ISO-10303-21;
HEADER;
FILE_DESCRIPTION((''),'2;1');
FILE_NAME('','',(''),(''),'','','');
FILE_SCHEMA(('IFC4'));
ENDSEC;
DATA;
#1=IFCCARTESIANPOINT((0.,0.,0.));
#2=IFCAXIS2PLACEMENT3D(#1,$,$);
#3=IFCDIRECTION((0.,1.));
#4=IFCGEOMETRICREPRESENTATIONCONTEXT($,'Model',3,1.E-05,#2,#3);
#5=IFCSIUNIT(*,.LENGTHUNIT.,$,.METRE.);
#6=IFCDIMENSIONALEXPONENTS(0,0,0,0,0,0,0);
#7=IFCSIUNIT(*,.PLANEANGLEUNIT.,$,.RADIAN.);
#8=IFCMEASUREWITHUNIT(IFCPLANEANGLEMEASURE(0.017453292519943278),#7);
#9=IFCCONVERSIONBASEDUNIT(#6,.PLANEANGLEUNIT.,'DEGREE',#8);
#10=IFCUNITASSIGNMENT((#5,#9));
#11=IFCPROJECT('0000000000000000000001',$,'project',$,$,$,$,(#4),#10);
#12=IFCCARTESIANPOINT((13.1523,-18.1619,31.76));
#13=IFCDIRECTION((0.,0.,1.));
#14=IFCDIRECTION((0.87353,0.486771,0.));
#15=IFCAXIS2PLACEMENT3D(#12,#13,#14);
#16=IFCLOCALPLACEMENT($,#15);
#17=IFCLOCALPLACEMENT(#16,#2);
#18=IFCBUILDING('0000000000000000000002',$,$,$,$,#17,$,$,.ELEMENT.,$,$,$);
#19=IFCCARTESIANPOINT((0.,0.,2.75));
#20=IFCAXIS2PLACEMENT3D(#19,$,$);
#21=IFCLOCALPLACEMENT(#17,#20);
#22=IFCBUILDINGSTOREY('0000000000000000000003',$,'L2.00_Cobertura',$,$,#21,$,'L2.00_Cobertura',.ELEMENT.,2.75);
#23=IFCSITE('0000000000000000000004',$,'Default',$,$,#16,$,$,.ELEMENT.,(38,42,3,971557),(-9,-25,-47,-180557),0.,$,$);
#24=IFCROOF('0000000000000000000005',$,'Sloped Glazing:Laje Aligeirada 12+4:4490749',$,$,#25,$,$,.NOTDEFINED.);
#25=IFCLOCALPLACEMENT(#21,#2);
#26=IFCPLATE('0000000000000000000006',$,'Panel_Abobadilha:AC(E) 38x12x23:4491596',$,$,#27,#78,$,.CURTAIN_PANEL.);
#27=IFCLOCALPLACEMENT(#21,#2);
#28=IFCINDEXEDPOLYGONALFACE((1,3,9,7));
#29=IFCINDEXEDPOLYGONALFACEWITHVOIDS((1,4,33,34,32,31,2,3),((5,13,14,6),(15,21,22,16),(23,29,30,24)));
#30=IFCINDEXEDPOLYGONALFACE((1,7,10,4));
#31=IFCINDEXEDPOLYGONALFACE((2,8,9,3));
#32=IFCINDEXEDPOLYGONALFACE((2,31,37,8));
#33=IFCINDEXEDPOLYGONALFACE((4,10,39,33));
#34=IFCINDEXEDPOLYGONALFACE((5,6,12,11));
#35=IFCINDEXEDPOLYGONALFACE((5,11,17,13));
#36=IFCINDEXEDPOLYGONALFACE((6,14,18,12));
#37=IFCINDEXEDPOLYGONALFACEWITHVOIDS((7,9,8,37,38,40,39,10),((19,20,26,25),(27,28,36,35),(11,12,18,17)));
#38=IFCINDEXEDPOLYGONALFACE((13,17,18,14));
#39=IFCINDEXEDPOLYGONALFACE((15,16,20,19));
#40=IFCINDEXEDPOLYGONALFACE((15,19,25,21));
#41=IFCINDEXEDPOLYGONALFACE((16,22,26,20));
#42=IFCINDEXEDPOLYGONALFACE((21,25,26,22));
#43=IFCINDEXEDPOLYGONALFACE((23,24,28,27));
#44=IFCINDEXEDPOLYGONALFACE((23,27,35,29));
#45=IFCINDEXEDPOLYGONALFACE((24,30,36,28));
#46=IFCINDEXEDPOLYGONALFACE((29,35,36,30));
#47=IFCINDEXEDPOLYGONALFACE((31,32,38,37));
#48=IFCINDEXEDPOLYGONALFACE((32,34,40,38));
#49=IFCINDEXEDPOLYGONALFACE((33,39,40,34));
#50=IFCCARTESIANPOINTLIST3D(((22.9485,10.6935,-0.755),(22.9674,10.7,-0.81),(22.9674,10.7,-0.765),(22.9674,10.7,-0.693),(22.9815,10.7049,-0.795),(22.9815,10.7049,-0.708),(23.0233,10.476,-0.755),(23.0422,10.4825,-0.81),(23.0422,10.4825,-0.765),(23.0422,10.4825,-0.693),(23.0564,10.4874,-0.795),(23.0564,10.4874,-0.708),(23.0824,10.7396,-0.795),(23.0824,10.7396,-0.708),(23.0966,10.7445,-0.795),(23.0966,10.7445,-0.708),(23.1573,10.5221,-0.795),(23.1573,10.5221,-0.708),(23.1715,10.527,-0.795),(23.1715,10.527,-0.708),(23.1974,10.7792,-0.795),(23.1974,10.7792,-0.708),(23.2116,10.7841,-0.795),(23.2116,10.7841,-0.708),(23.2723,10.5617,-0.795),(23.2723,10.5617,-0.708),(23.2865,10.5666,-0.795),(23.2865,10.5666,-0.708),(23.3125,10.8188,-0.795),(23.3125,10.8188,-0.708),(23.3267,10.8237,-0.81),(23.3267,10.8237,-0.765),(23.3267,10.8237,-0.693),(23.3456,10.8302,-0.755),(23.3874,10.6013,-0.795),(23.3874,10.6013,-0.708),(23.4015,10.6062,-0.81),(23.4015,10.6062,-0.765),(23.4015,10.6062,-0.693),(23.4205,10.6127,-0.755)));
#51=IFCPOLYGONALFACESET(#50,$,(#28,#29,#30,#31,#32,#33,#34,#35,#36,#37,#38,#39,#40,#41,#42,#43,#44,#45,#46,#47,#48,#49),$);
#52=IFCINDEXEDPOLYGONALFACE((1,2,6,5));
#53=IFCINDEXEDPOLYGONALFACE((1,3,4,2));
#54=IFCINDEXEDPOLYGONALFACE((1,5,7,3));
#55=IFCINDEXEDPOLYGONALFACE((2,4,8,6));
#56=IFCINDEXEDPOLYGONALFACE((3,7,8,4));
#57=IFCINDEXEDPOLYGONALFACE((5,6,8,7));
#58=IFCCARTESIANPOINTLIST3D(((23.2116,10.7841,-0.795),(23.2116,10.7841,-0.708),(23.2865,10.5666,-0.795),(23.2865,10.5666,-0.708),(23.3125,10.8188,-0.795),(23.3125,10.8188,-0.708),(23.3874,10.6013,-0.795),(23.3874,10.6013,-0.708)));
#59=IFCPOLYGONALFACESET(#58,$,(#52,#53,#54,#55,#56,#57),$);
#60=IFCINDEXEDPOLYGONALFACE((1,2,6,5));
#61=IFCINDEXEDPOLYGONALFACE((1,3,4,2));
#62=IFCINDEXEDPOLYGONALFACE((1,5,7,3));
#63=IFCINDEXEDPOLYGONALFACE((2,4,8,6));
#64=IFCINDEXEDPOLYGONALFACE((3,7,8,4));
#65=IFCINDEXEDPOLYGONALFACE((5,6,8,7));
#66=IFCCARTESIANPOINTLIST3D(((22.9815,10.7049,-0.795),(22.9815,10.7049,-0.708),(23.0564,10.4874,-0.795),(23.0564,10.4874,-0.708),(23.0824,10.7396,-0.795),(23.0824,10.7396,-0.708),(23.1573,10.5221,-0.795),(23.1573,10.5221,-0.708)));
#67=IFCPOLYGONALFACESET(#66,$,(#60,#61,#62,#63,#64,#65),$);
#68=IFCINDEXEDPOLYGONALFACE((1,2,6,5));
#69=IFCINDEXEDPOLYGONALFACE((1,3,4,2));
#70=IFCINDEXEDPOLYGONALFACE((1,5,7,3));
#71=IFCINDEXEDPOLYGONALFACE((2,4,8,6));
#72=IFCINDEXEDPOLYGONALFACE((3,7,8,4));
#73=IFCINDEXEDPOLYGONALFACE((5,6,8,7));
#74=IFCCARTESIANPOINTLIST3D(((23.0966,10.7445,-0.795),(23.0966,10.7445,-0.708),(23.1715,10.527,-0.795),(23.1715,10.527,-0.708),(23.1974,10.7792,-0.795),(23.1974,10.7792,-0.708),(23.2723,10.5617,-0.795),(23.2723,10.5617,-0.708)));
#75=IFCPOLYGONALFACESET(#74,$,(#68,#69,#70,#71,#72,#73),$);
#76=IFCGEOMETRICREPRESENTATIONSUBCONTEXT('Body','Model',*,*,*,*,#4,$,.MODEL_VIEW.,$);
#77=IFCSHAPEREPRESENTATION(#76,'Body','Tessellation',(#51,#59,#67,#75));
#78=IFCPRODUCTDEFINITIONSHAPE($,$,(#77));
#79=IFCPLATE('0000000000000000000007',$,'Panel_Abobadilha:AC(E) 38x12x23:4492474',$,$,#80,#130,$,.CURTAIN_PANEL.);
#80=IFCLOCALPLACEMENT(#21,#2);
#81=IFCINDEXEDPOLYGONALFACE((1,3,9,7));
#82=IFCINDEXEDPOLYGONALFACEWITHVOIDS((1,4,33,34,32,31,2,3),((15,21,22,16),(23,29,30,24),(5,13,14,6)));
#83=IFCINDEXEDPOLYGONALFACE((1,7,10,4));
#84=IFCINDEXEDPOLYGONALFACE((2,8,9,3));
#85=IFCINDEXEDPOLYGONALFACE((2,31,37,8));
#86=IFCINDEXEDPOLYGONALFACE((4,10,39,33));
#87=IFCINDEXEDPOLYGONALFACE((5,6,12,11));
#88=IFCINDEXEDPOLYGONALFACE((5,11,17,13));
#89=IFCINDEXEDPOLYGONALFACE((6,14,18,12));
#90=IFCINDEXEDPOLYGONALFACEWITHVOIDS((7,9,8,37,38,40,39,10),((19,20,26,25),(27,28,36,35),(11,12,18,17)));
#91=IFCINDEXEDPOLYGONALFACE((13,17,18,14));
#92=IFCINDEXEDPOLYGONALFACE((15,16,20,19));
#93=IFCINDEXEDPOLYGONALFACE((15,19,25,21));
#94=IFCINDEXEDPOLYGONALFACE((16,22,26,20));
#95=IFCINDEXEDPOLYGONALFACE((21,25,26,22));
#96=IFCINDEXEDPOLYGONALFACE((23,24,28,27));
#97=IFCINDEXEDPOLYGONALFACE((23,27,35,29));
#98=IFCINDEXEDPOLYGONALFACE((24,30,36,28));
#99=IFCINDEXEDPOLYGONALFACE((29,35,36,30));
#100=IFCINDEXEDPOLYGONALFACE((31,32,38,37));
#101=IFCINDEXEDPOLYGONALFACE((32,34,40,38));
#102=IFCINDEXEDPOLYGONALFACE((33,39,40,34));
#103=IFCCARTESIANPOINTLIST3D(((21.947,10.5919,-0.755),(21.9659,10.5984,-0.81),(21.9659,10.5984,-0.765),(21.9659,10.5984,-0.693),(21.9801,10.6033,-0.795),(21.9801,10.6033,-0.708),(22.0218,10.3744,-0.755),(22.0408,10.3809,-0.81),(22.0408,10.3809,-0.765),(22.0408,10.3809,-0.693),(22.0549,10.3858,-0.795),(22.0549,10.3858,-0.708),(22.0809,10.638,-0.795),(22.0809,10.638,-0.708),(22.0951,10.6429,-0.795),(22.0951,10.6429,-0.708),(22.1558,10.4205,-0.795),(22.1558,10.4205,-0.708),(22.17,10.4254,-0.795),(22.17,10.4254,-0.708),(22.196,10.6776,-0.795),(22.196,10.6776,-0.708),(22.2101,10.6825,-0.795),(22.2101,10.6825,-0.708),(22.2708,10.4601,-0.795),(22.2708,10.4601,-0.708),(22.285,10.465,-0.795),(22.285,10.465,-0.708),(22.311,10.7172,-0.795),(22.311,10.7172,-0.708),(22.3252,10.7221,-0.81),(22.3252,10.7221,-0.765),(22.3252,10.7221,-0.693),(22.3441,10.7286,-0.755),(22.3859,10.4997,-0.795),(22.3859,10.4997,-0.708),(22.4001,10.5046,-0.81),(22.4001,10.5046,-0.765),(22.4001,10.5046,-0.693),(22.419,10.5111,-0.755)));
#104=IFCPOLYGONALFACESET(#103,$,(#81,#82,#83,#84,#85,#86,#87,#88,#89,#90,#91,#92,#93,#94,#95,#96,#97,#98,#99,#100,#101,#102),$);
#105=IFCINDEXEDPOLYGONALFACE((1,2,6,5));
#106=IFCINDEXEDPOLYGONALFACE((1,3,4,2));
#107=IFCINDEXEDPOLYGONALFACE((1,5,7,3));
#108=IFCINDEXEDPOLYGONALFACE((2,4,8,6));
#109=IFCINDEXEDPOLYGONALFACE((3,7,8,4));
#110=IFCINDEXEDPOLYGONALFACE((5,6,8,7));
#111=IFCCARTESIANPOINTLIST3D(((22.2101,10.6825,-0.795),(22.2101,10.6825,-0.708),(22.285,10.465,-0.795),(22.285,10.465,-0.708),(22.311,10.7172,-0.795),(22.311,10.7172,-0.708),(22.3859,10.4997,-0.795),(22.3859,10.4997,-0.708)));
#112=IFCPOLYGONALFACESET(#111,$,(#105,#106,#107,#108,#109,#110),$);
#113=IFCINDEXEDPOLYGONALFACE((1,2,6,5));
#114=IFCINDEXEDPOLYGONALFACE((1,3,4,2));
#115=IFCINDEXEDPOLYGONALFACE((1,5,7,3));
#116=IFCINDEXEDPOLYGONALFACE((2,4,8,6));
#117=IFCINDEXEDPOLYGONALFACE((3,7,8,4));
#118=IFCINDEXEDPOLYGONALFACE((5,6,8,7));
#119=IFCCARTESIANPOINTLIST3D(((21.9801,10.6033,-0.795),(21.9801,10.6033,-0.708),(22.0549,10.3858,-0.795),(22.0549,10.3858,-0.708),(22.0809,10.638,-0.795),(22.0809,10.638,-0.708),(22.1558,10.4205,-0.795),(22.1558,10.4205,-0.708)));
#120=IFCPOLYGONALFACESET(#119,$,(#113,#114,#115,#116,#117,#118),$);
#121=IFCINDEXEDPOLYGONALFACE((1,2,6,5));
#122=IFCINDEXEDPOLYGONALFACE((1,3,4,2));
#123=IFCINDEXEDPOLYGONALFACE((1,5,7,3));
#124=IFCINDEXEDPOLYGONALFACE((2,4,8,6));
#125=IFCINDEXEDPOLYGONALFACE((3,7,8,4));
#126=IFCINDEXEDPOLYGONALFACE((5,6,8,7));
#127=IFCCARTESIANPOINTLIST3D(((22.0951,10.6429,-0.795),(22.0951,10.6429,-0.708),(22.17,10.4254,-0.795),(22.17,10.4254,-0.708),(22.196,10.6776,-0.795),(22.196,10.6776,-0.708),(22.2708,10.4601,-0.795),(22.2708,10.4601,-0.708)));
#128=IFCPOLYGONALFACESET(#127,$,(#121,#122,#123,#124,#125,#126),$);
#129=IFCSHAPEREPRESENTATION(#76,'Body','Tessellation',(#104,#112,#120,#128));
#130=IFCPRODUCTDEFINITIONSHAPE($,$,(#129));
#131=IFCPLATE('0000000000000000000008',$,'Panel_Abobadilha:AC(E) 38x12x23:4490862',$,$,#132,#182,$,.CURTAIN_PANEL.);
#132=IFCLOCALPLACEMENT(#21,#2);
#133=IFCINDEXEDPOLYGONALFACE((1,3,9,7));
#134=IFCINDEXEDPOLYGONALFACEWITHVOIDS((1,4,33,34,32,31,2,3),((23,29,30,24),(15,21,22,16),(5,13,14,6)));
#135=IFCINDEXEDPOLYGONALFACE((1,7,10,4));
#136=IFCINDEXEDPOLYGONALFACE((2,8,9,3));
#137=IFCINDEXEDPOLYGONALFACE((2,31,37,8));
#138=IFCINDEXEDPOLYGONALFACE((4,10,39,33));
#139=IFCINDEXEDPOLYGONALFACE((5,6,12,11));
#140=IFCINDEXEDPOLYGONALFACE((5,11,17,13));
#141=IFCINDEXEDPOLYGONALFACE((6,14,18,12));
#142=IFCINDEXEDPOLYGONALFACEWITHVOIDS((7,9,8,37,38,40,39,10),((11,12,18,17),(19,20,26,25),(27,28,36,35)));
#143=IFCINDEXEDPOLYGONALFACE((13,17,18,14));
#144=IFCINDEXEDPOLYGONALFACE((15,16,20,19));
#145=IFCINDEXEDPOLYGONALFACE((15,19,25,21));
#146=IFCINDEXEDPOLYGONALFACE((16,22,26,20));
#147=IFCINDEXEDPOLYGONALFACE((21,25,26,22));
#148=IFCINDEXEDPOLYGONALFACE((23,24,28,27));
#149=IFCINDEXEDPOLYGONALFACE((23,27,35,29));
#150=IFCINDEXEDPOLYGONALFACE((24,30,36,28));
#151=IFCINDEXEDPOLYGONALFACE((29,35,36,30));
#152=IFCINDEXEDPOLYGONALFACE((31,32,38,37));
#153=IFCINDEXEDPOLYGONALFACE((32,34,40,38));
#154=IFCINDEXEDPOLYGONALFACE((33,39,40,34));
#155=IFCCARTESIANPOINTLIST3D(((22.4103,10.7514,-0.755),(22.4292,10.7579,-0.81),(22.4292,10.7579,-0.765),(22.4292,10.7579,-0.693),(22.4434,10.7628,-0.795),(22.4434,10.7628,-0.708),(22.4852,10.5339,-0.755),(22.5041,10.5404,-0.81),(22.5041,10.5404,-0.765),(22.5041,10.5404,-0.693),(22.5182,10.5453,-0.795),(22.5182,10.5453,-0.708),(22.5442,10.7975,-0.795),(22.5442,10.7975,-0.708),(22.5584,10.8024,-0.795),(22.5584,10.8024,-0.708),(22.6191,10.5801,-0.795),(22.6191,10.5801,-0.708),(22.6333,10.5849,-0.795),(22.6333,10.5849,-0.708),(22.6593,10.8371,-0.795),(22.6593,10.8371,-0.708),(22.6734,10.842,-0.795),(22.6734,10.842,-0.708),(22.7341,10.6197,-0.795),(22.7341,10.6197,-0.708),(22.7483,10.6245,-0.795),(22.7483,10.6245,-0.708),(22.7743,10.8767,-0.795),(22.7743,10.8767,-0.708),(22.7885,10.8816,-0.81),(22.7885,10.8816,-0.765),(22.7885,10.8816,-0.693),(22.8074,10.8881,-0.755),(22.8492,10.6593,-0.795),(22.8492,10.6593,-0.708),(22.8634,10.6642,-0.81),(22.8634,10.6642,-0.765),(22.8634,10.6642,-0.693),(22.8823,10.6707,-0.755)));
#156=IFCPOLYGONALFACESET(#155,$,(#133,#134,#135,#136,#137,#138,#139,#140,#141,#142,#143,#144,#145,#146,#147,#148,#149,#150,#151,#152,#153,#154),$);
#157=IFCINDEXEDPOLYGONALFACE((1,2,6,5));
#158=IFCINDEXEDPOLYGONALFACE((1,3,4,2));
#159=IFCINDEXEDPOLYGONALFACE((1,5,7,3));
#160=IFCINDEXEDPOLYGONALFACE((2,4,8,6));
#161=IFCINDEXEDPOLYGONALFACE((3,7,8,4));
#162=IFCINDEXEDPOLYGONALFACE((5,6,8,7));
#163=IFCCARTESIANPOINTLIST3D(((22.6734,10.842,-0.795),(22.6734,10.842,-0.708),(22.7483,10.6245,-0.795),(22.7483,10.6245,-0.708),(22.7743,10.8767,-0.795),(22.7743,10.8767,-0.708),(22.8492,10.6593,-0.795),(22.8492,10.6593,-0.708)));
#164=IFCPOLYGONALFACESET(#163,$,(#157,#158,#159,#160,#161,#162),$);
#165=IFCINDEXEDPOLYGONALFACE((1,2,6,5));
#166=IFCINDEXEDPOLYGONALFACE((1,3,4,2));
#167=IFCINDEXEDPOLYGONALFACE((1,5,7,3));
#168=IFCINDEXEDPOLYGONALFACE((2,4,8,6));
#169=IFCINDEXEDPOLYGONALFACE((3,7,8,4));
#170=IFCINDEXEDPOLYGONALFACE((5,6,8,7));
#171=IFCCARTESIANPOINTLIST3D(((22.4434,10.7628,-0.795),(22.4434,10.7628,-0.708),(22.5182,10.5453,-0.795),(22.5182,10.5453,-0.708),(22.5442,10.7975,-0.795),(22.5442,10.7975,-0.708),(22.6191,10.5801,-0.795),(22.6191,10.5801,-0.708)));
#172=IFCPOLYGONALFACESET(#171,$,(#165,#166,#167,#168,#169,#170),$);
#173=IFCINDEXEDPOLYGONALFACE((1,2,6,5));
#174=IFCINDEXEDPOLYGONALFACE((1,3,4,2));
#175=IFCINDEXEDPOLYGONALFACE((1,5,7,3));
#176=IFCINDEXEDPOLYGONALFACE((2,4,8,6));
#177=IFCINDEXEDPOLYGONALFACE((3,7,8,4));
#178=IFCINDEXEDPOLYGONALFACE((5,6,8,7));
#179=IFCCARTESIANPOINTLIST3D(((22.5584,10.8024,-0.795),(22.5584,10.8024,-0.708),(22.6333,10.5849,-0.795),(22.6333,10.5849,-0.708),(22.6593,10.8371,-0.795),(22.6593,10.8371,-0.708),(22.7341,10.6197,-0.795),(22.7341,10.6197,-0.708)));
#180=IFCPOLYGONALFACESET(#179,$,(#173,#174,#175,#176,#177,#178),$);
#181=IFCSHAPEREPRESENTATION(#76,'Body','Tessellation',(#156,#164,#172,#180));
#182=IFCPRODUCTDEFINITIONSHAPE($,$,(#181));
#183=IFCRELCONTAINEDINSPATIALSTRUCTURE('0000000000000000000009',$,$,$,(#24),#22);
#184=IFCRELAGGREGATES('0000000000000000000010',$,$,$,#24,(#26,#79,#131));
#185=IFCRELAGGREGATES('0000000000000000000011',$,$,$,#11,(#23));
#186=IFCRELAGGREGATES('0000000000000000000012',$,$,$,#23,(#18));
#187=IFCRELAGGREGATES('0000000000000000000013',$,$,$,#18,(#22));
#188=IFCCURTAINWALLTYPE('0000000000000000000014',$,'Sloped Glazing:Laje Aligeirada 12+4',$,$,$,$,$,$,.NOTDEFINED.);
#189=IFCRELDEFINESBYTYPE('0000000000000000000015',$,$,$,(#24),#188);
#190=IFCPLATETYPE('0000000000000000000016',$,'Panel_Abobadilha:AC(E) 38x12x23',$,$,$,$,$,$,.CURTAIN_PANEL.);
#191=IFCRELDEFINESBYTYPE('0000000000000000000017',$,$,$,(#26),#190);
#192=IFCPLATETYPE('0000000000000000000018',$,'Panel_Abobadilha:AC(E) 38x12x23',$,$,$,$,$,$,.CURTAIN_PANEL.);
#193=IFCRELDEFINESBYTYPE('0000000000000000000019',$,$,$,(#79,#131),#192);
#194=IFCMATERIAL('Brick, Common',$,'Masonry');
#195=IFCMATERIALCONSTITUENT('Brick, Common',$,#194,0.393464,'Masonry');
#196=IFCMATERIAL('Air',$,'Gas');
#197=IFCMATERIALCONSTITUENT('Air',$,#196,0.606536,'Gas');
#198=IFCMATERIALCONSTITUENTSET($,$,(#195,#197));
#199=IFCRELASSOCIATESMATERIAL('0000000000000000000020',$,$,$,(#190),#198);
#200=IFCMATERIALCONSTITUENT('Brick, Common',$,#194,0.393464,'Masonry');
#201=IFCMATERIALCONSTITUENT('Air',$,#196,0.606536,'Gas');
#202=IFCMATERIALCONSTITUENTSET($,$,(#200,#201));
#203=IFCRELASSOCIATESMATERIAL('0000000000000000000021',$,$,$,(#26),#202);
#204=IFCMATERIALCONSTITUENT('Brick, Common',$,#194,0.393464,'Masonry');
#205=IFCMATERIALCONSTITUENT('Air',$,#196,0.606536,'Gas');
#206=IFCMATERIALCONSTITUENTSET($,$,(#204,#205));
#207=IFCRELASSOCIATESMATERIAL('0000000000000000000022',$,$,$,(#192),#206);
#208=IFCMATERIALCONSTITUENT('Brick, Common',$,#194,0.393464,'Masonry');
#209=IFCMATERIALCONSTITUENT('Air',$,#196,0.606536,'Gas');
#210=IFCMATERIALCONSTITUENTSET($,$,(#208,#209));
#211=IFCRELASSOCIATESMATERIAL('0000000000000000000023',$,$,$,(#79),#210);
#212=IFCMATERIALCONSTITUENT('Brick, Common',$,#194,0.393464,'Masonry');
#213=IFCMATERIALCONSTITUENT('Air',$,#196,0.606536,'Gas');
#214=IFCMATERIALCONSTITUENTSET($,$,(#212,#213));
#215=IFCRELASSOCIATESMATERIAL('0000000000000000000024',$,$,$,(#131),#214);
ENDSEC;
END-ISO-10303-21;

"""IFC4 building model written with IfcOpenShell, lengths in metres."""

from ifc_helpers import new_model, entity, si_unit, converted_unit, direction, frame, origin, place, context, subcontext, project, spatial, indexed_curve, outline, extrude, source, transform, mapped, material, constituent, constituent_set, type_object, type_shapes, element, aggregate, save


model = new_model("IFC4")

# Units and contexts
model_context = context("Model", 3, precision=1e-05, world=origin(), true_north=direction((0.0, 1.0)))
body_context = subcontext(model_context, "Body", "Model", "MODEL_VIEW")
ifc_project = project(units=[si_unit("LENGTHUNIT", "METRE"), converted_unit("PLANEANGLEUNIT", "DEGREE", entity("IfcPlaneAngleMeasure", 0.017453292519943278), si_unit("PLANEANGLEUNIT", "RADIAN"), dimensions=[0, 0, 0, 0, 0, 0, 0])], contexts=[model_context])

# Site, building, storey
site_placement = place(None, frame((13.1523, -18.1619, 31.76), z_axis=(0.0, 0.0, 1.0), x_axis=(0.87353, 0.486771, 0.0)))
site = spatial("IfcSite", under=ifc_project, at=site_placement, Name="Default", CompositionType="ELEMENT", RefLatitude=(38, 42, 3, 971557), RefLongitude=(-9, -25, -47, -180557), RefElevation=0.0)
building_placement = place(site_placement, origin())
building = spatial("IfcBuilding", under=site, at=building_placement, CompositionType="ELEMENT")
storey_placement = place(building_placement, frame((0.0, 0.0, 2.75)))
storey = spatial("IfcBuildingStorey", under=building, at=storey_placement, Name="L2.00_Cobertura", LongName="L2.00_Cobertura", CompositionType="ELEMENT", Elevation=2.75)

# Roof
curtain_wall_type = type_object("IfcCurtainWallType", Name="Sloped Glazing:Laje Aligeirada 12+4", PredefinedType="NOTDEFINED")
roof_placement = place(storey_placement, frame((0.0, 0.0, -2.75)))
roof = element("IfcRoof", 1, at=roof_placement, inside=storey, type_object=curtain_wall_type, Name="Sloped Glazing:Laje Aligeirada 12+4:4490749", PredefinedType="NOTDEFINED")

# Plates
ifc_material_1 = material(Name="Brick, Common", Category="Masonry")
ifc_constituent_1 = constituent(ifc_material_1, Name="Brick, Common", Category="Masonry", fraction=0.393464)
ifc_material_2 = material(Name="Air", Category="Gas")
ifc_constituent_2 = constituent(ifc_material_2, Name="Air", Category="Gas", fraction=0.606536)
ifc_constituent_set_1 = constituent_set(constituents=[ifc_constituent_1, ifc_constituent_2])
ifc_constituent_3 = constituent(ifc_material_1, Name="Brick, Common", Category="Masonry", fraction=0.393464)
ifc_constituent_4 = constituent(ifc_material_2, Name="Air", Category="Gas", fraction=0.606536)
ifc_constituent_set_2 = constituent_set(constituents=[ifc_constituent_3, ifc_constituent_4])
plate_type_1 = type_object("IfcPlateType", Name="Panel_Abobadilha:AC(E) 38x12x23", PredefinedType="CURTAIN_PANEL", material=ifc_constituent_set_2)
shared_shape_1 = source(origin(), body_context, "Body", "SweptSolid", [
    extrude(outline(indexed_curve([(-0.19, -0.0543), (0.19, -0.0543), (0.19, -0.0093), (0.21, 0.0007), (0.19, 0.0628), (-0.19, 0.0628), (-0.21, 0.0007), (-0.19, -0.0093), (-0.19, -0.0543)], self_intersect=False), holes=[indexed_curve([(-0.0683, 0.0477), (-0.0683, -0.0393), (-0.175, -0.0393), (-0.175, 0.0477), (-0.0683, 0.0477)], self_intersect=False), indexed_curve([(0.0533, 0.0477), (0.0533, -0.0393), (-0.0533, -0.0393), (-0.0533, 0.0477), (0.0533, 0.0477)], self_intersect=False), indexed_curve([(0.175, 0.0477), (0.175, -0.0393), (0.0683, -0.0393), (0.0683, 0.0477), (0.175, 0.0477)], self_intersect=False)]), frame((0.0, 0.0543, 0.0)), (0.0, 0.0, 1.0), 0.23),
    extrude(outline(indexed_curve([(-0.0533, -0.0435), (0.0533, -0.0435), (0.0533, 0.0435), (-0.0533, 0.0435), (-0.0533, -0.0435)], self_intersect=False)), frame((0.1217, 0.0585, 0.0), z_axis=(0.0, 0.0, 1.0), x_axis=(-1.0, 0.0, 0.0)), (0.0, 0.0, 1.0), 0.23),
    extrude(outline(indexed_curve([(-0.0533, -0.0435), (0.0533, -0.0435), (0.0533, 0.0435), (-0.0533, 0.0435), (-0.0533, -0.0435)], self_intersect=False)), frame((-0.1217, 0.0585, 0.0), z_axis=(0.0, 0.0, 1.0), x_axis=(-1.0, 0.0, 0.0)), (0.0, 0.0, 1.0), 0.23),
    extrude(outline(indexed_curve([(-0.0533, -0.0435), (0.0533, -0.0435), (0.0533, 0.0435), (-0.0533, 0.0435), (-0.0533, -0.0435)], self_intersect=False)), frame((0.0, 0.0585, 0.0), z_axis=(0.0, 0.0, 1.0), x_axis=(-1.0, 0.0, 0.0)), (0.0, 0.0, 1.0), 0.23),
])
type_shapes(plate_type_1, [shared_shape_1])
plate_1_placement = place(roof_placement, frame((23.147, 10.7618, 1.94), z_axis=(0.325568, -0.945519, 0.0), x_axis=(0.945519, 0.325568, 0.0)))
plate_1 = element("IfcPlate", 2, at=plate_1_placement, type_object=plate_type_1, material=ifc_constituent_set_1, Name="Panel_Abobadilha:AC(E) 38x12x23:4491596", PredefinedType="CURTAIN_PANEL", context=body_context, shape_type="MappedRepresentation", body=[
    mapped(shared_shape_1, transform((0.0, 0.0, 0.0), scale=1.0)),
])
ifc_constituent_5 = constituent(ifc_material_1, Name="Brick, Common", Category="Masonry", fraction=0.393464)
ifc_constituent_6 = constituent(ifc_material_2, Name="Air", Category="Gas", fraction=0.606536)
ifc_constituent_set_3 = constituent_set(constituents=[ifc_constituent_5, ifc_constituent_6])
ifc_constituent_7 = constituent(ifc_material_1, Name="Brick, Common", Category="Masonry", fraction=0.393464)
ifc_constituent_8 = constituent(ifc_material_2, Name="Air", Category="Gas", fraction=0.606536)
ifc_constituent_set_4 = constituent_set(constituents=[ifc_constituent_7, ifc_constituent_8])
plate_type_2 = type_object("IfcPlateType", Name="Panel_Abobadilha:AC(E) 38x12x23", PredefinedType="CURTAIN_PANEL", material=ifc_constituent_set_4)
shared_shape_2 = source(origin(), body_context, "Body", "SweptSolid", [
    extrude(outline(indexed_curve([(-0.19, -0.0543), (0.19, -0.0543), (0.19, -0.0093), (0.21, 0.0007), (0.19, 0.0628), (-0.19, 0.0628), (-0.21, 0.0007), (-0.19, -0.0093), (-0.19, -0.0543)], self_intersect=False), holes=[indexed_curve([(-0.0683, 0.0477), (-0.0683, -0.0393), (-0.175, -0.0393), (-0.175, 0.0477), (-0.0683, 0.0477)], self_intersect=False), indexed_curve([(0.0533, 0.0477), (0.0533, -0.0393), (-0.0533, -0.0393), (-0.0533, 0.0477), (0.0533, 0.0477)], self_intersect=False), indexed_curve([(0.175, 0.0477), (0.175, -0.0393), (0.0683, -0.0393), (0.0683, 0.0477), (0.175, 0.0477)], self_intersect=False)]), frame((0.0, 0.0543, 0.0)), (0.0, 0.0, 1.0), 0.23),
    extrude(outline(indexed_curve([(-0.0533, -0.0435), (0.0533, -0.0435), (0.0533, 0.0435), (-0.0533, 0.0435), (-0.0533, -0.0435)], self_intersect=False)), frame((0.1217, 0.0585, 0.0), z_axis=(0.0, 0.0, 1.0), x_axis=(-1.0, 0.0, 0.0)), (0.0, 0.0, 1.0), 0.23),
    extrude(outline(indexed_curve([(-0.0533, -0.0435), (0.0533, -0.0435), (0.0533, 0.0435), (-0.0533, 0.0435), (-0.0533, -0.0435)], self_intersect=False)), frame((-0.1217, 0.0585, 0.0), z_axis=(0.0, 0.0, 1.0), x_axis=(-1.0, 0.0, 0.0)), (0.0, 0.0, 1.0), 0.23),
    extrude(outline(indexed_curve([(-0.0533, -0.0435), (0.0533, -0.0435), (0.0533, 0.0435), (-0.0533, 0.0435), (-0.0533, -0.0435)], self_intersect=False)), frame((0.0, 0.0585, 0.0), z_axis=(0.0, 0.0, 1.0), x_axis=(-1.0, 0.0, 0.0)), (0.0, 0.0, 1.0), 0.23),
])
type_shapes(plate_type_2, [shared_shape_2])
plate_2_placement = place(roof_placement, frame((22.1455, 10.6602, 1.94), z_axis=(0.325568, -0.945519, 0.0), x_axis=(0.945519, 0.325568, 0.0)))
plate_2 = element("IfcPlate", 3, at=plate_2_placement, type_object=plate_type_2, material=ifc_constituent_set_3, Name="Panel_Abobadilha:AC(E) 38x12x23:4492474", PredefinedType="CURTAIN_PANEL", context=body_context, shape_type="MappedRepresentation", body=[
    mapped(shared_shape_2, transform((0.0, 0.0, 0.0), scale=1.0)),
])
ifc_constituent_9 = constituent(ifc_material_1, Name="Brick, Common", Category="Masonry", fraction=0.393464)
ifc_constituent_10 = constituent(ifc_material_2, Name="Air", Category="Gas", fraction=0.606536)
ifc_constituent_set_5 = constituent_set(constituents=[ifc_constituent_9, ifc_constituent_10])
plate_3_placement = place(roof_placement, frame((22.6088, 10.8198, 1.94), z_axis=(0.325568, -0.945519, 0.0), x_axis=(0.945519, 0.325568, 0.0)))
plate_3 = element("IfcPlate", 4, at=plate_3_placement, type_object=plate_type_2, material=ifc_constituent_set_5, Name="Panel_Abobadilha:AC(E) 38x12x23:4490862", PredefinedType="CURTAIN_PANEL", context=body_context, shape_type="MappedRepresentation", body=[
    mapped(shared_shape_2, transform((0.0, 0.0, 0.0), scale=1.0)),
])
aggregate(roof, [plate_1, plate_2, plate_3])

save(model, "model.ifc")
